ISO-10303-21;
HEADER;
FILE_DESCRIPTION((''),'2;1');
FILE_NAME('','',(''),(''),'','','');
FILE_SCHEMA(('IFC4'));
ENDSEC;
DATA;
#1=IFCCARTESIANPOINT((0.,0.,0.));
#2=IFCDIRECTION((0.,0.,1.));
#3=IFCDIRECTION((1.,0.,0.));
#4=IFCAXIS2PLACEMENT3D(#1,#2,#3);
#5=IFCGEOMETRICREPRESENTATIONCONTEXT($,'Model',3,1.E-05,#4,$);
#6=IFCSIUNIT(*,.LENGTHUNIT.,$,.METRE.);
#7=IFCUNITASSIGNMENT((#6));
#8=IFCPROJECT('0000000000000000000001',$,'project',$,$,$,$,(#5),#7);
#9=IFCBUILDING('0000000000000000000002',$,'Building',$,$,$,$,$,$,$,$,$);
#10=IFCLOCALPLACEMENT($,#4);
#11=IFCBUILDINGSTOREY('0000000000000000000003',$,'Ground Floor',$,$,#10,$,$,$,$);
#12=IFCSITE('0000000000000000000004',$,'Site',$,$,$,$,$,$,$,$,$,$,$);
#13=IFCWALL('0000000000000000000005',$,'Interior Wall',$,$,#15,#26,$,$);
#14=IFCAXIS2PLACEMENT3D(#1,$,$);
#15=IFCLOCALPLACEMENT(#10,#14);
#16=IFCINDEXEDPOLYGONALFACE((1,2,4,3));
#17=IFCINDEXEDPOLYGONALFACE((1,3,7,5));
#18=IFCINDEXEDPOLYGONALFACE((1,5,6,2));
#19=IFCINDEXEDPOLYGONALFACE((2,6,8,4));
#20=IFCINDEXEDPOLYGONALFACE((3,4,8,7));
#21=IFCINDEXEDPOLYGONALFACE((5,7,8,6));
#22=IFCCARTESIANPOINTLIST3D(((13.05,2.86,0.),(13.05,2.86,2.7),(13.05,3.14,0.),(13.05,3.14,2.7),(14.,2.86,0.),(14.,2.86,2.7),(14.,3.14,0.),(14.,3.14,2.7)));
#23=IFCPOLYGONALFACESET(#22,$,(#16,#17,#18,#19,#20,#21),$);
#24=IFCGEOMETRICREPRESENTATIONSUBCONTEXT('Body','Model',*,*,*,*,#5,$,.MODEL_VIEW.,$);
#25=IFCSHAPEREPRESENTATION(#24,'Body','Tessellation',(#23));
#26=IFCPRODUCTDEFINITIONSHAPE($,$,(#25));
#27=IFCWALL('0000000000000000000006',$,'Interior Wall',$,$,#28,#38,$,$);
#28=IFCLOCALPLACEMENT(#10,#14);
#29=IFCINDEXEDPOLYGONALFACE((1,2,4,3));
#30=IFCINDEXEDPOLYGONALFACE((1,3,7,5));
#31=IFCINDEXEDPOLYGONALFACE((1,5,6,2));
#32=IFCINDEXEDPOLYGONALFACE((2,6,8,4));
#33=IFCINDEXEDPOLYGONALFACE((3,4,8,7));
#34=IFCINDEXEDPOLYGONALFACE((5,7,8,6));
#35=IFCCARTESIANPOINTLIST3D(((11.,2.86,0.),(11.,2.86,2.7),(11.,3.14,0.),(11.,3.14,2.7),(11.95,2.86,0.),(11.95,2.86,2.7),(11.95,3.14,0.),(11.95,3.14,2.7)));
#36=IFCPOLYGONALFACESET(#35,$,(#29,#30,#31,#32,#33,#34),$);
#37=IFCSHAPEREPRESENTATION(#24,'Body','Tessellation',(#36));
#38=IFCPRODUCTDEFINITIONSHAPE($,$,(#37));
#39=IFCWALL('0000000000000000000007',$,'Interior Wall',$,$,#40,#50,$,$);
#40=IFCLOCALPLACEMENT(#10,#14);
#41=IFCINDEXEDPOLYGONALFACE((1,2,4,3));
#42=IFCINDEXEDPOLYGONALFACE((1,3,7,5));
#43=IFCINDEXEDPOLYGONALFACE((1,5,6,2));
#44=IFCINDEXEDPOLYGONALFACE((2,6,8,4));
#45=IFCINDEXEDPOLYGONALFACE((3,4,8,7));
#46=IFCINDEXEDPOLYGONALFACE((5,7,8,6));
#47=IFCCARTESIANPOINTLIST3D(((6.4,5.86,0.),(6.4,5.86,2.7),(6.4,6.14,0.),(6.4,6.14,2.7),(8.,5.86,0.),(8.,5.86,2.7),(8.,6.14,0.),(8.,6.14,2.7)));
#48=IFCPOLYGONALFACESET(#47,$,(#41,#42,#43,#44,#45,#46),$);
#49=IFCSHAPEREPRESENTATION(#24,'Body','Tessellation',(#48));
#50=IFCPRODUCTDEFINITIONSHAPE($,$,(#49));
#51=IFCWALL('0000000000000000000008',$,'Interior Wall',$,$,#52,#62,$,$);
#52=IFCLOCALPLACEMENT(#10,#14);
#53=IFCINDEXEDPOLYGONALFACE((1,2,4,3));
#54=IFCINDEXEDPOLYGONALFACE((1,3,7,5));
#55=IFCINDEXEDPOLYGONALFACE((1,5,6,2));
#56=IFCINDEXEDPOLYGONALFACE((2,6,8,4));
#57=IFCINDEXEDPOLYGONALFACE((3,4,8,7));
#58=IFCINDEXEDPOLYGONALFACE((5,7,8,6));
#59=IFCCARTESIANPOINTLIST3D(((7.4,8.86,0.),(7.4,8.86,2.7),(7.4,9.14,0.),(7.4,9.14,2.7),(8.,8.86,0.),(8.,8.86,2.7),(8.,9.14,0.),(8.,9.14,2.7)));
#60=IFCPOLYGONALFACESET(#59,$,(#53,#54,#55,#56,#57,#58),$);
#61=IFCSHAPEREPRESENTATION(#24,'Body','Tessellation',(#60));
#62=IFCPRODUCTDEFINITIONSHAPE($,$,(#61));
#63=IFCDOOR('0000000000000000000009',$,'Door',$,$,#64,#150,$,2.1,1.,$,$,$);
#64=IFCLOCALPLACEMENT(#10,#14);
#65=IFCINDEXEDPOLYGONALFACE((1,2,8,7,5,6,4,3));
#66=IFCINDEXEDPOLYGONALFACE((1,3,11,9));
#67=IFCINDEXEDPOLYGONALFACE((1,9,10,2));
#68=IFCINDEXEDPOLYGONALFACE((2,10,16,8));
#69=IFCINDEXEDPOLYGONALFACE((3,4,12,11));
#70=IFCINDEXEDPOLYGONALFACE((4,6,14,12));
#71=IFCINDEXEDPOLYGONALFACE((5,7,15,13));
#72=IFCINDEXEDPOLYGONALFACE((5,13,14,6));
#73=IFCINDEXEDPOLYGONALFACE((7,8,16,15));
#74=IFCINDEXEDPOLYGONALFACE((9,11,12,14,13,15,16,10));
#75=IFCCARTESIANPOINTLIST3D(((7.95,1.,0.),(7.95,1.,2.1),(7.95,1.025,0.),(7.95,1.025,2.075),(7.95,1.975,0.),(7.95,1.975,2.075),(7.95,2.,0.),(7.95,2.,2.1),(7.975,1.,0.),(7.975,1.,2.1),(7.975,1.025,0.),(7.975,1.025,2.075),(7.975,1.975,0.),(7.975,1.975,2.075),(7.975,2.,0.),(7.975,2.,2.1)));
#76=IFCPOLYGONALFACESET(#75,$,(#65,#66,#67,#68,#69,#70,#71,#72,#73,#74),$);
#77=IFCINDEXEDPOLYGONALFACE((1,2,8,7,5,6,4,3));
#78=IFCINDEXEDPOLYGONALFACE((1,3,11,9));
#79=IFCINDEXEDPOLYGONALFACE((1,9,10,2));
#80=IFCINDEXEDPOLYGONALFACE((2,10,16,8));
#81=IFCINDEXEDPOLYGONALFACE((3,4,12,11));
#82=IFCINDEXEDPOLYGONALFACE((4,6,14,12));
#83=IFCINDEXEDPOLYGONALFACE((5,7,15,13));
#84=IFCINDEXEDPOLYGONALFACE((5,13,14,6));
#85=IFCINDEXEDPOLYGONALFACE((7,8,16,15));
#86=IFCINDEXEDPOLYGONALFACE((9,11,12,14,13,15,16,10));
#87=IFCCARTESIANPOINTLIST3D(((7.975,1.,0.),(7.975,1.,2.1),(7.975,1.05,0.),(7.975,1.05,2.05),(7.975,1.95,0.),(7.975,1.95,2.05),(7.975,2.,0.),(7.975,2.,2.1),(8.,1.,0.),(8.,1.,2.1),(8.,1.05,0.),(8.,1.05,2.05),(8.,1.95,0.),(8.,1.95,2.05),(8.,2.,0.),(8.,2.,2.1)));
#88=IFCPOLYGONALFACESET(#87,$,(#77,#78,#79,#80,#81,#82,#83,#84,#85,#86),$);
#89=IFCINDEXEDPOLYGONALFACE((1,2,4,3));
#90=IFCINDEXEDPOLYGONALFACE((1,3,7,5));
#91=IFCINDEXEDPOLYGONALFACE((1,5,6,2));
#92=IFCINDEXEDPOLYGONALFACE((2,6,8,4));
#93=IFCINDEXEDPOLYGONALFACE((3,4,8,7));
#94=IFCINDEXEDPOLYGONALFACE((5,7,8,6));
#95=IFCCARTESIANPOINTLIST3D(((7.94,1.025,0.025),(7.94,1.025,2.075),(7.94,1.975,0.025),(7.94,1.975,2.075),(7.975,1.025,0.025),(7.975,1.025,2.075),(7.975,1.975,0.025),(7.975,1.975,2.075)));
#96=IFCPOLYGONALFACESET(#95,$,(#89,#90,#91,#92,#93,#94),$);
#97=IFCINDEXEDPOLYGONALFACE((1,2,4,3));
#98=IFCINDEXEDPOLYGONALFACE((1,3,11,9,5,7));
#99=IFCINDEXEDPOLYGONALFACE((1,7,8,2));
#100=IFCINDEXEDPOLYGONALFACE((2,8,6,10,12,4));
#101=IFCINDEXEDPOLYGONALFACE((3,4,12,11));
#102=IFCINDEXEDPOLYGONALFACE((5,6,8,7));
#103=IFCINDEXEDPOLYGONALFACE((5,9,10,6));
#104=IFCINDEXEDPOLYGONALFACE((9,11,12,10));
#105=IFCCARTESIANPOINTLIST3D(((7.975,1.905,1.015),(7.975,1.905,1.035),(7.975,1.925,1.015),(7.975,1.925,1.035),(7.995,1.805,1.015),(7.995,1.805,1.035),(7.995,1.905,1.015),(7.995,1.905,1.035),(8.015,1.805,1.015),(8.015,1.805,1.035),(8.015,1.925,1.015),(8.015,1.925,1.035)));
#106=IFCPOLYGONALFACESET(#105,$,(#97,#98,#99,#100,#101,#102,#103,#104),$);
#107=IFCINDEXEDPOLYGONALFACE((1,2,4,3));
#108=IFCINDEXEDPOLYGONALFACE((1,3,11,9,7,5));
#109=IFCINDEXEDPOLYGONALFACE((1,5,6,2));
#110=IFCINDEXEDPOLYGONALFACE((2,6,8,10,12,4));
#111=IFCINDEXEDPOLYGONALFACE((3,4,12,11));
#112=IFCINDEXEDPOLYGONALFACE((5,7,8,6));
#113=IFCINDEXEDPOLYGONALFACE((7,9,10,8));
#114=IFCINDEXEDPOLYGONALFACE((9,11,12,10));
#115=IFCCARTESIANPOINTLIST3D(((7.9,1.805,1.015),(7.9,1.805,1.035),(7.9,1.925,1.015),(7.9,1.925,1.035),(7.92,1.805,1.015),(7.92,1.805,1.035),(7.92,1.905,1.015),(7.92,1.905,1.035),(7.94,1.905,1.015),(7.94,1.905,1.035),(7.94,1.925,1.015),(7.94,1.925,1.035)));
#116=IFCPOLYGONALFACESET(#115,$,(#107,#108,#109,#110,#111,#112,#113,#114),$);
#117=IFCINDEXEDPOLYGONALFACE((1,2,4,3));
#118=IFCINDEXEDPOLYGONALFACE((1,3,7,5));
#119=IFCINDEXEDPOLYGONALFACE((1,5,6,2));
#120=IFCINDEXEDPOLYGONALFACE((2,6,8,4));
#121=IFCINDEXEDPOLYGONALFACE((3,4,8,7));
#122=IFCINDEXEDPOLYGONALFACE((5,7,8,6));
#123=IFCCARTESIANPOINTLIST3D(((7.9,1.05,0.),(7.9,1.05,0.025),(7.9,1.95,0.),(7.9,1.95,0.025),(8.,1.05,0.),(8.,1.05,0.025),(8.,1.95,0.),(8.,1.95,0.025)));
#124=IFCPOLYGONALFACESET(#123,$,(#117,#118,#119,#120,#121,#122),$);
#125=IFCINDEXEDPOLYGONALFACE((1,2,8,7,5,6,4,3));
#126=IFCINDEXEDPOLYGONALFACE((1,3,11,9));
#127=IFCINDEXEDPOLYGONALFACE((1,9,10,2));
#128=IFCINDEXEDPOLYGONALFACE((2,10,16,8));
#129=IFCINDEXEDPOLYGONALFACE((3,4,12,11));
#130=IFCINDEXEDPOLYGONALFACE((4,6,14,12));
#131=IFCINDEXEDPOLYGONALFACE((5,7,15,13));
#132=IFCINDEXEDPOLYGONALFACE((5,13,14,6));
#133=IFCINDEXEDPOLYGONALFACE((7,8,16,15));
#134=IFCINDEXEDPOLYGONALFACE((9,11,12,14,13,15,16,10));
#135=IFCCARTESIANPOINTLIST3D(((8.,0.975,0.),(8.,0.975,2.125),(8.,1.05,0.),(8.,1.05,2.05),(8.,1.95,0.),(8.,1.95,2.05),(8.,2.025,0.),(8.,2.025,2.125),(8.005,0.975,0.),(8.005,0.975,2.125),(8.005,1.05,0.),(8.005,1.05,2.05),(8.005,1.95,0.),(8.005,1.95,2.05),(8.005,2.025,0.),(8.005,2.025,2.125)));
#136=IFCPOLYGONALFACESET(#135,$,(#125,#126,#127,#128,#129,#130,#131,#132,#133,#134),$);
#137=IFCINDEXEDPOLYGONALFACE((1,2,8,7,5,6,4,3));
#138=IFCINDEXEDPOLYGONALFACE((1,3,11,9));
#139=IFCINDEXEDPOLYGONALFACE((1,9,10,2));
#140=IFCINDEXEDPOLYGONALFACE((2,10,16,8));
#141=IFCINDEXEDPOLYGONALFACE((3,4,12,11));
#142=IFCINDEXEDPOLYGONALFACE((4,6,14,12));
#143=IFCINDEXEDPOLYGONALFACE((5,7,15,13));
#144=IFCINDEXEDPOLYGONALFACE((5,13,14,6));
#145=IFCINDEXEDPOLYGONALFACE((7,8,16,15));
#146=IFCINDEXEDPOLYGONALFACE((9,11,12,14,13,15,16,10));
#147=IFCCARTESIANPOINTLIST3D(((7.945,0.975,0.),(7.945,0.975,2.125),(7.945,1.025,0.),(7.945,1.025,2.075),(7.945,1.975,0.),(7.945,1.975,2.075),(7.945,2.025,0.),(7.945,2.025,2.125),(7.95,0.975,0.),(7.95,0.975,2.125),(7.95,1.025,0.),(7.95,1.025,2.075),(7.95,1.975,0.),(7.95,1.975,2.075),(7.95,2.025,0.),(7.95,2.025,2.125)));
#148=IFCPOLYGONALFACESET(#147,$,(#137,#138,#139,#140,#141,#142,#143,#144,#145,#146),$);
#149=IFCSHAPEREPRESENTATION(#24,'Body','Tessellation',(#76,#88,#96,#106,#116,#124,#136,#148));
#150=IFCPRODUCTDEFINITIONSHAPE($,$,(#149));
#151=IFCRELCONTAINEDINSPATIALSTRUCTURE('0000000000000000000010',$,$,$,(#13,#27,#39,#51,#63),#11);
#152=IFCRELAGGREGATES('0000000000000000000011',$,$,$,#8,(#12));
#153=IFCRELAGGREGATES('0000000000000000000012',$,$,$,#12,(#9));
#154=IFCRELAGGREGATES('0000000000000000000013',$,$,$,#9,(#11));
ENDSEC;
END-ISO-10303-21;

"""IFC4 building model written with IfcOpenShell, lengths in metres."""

from ifc_helpers import new_model, si_unit, frame, origin_with_axes, place, context, subcontext, project, spatial, line, indexed_curve, outline, extrude, element, save


model = new_model("IFC4")

# Units and contexts
model_context = context("Model", 3, precision=1e-05, world=origin_with_axes())
body_context = subcontext(model_context, "Body", "Model", "MODEL_VIEW")
ifc_project = project(units=[si_unit("LENGTHUNIT", "METRE")], contexts=[model_context])

# Site, building, storey
site = spatial("IfcSite", under=ifc_project, Name="Site")
building = spatial("IfcBuilding", under=site, Name="Building")
storey_placement = place(None, origin_with_axes())
storey = spatial("IfcBuildingStorey", under=building, at=storey_placement, Name="Ground Floor")

# Walls
for number, where, z_axis, x_axis, name in (
    (1, (14.0, 3.0, 0.0), (0.0, 0.0, 1.0), (-1.0, 0.0, 0.0), "Interior Wall"),
    (2, (11.95, 3.0, 0.0), (0.0, 0.0, 1.0), (-1.0, 0.0, 0.0), "Interior Wall"),
):
    element("IfcWall", number, at=place(storey_placement, frame(where, z_axis=z_axis, x_axis=x_axis)), inside=storey, Name=name, context=body_context, shape_type="SweptSolid", body=[
        extrude(outline(indexed_curve([(0.0, 0.0), (0.0, 0.28), (0.95, 0.28), (0.95, 0.0), (0.0, 0.0)], self_intersect=False)), frame((0.0, -0.14, 0.0), z_axis=(0.0, 0.0, 1.0), x_axis=(1.0, 0.0, 0.0)), (0.0, 0.0, 1.0), 2.7),
    ])
wall_1_placement = place(storey_placement, frame((8.0, 6.0, 0.0), z_axis=(0.0, 0.0, 1.0), x_axis=(-1.0, 0.0, 0.0)))
element("IfcWall", 3, at=wall_1_placement, inside=storey, Name="Interior Wall", context=body_context, shape_type="SweptSolid", body=[
    extrude(outline(indexed_curve([(0.0, 0.0), (0.0, 0.28), (1.6, 0.28), (1.6, 0.0), (0.0, 0.0)], self_intersect=False)), frame((0.0, -0.14, 0.0), z_axis=(0.0, 0.0, 1.0), x_axis=(1.0, 0.0, 0.0)), (0.0, 0.0, 1.0), 2.7),
])
wall_2_placement = place(storey_placement, frame((8.0, 9.0, 0.0), z_axis=(0.0, 0.0, 1.0), x_axis=(-1.0, 0.0, 0.0)))
element("IfcWall", 4, at=wall_2_placement, inside=storey, Name="Interior Wall", context=body_context, shape_type="SweptSolid", body=[
    extrude(outline(indexed_curve([(0.0, 0.0), (0.0, 0.28), (0.6, 0.28), (0.6, 0.0), (0.0, 0.0)], self_intersect=False)), frame((0.0, -0.14, 0.0), z_axis=(0.0, 0.0, 1.0), x_axis=(1.0, 0.0, 0.0)), (0.0, 0.0, 1.0), 2.7),
])

# Door
door_1_placement = place(storey_placement, frame((8.0, 1.0, 0.0), z_axis=(0.0, 0.0, 1.0), x_axis=(0.0, 1.0, 0.0)))
element("IfcDoor", 5, at=door_1_placement, inside=storey, Name="Door", OverallHeight=2.1, OverallWidth=1.0, context=body_context, shape_type="SweptSolid", body=[
    extrude(outline(indexed_curve([(0.0, 0.0), (0.0, 2.1), (1.0, 2.1), (1.0, 0.0), (0.975, 0.0), (0.975, 2.075), (0.025, 2.075), (0.025, 0.0)], segments=[line(1, 2, 3, 4, 5, 6, 7, 8, 1)])), frame((0.0, 0.025, 0.0), z_axis=(0.0, -1.0, 0.0), x_axis=(1.0, 0.0, 0.0)), (0.0, 0.0, -1.0), 0.025),
    extrude(outline(indexed_curve([(0.0, 0.0), (0.0, 2.1), (1.0, 2.1), (1.0, 0.0), (0.95, 0.0), (0.95, 2.05), (0.05, 2.05), (0.05, 0.0)], segments=[line(1, 2, 3, 4, 5, 6, 7, 8, 1)])), frame((0.0, 0.0, 0.0), z_axis=(0.0, -1.0, 0.0), x_axis=(1.0, 0.0, 0.0)), (0.0, 0.0, -1.0), 0.025),
    extrude(outline(indexed_curve([(0.0, 0.0), (0.95, 0.0), (0.95, 0.035), (0.0, 0.035)], segments=[line(1, 2, 3, 4, 1)])), frame((0.025, 0.025, 0.025), z_axis=(0.0, 0.0, 1.0), x_axis=(1.0, 0.0, 0.0)), (0.0, 0.0, 1.0), 2.05),
    extrude(outline(indexed_curve([(0.0, 0.0), (0.0, -0.04), (-0.12, -0.04), (-0.12, -0.02), (-0.02, -0.02), (-0.02, 0.0)], segments=[line(1, 2, 3, 4, 5, 6, 1)])), frame((0.925, 0.025, 1.015), z_axis=(0.0, 0.0, 1.0), x_axis=(1.0, 0.0, 0.0)), (0.0, 0.0, 1.0), 0.02),
    extrude(outline(indexed_curve([(0.0, 0.0), (0.0, 0.04), (-0.12, 0.04), (-0.12, 0.02), (-0.02, 0.02), (-0.02, 0.0)], segments=[line(1, 2, 3, 4, 5, 6, 1)])), frame((0.925, 0.06, 1.015), z_axis=(0.0, 0.0, 1.0), x_axis=(1.0, 0.0, 0.0)), (0.0, 0.0, 1.0), 0.02),
    extrude(outline(indexed_curve([(0.0, 0.0), (0.9, 0.0), (0.9, 0.1), (0.0, 0.1)], segments=[line(1, 2, 3, 4, 1)])), frame((0.05, 0.0, 0.0), z_axis=(0.0, 0.0, 1.0), x_axis=(1.0, 0.0, 0.0)), (0.0, 0.0, 1.0), 0.025),
    extrude(outline(indexed_curve([(0.0, 0.0), (0.0, 2.125), (1.05, 2.125), (1.05, 0.0), (0.975, 0.0), (0.975, 2.05), (0.075, 2.05), (0.075, 0.0)], segments=[line(1, 2, 3, 4, 5, 6, 7, 8, 1)])), frame((-0.025, -0.005, 0.0), z_axis=(0.0, -1.0, 0.0), x_axis=(1.0, 0.0, 0.0)), (0.0, 0.0, -1.0), 0.005),
    extrude(outline(indexed_curve([(0.0, 0.0), (0.0, 2.125), (1.05, 2.125), (1.05, 0.0), (1.0, 0.0), (1.0, 2.075), (0.05, 2.075), (0.05, 0.0)], segments=[line(1, 2, 3, 4, 5, 6, 7, 8, 1)])), frame((-0.025, 0.05, 0.0), z_axis=(0.0, -1.0, 0.0), x_axis=(1.0, 0.0, 0.0)), (0.0, 0.0, -1.0), 0.005),
])

save(model, "model.ifc")
